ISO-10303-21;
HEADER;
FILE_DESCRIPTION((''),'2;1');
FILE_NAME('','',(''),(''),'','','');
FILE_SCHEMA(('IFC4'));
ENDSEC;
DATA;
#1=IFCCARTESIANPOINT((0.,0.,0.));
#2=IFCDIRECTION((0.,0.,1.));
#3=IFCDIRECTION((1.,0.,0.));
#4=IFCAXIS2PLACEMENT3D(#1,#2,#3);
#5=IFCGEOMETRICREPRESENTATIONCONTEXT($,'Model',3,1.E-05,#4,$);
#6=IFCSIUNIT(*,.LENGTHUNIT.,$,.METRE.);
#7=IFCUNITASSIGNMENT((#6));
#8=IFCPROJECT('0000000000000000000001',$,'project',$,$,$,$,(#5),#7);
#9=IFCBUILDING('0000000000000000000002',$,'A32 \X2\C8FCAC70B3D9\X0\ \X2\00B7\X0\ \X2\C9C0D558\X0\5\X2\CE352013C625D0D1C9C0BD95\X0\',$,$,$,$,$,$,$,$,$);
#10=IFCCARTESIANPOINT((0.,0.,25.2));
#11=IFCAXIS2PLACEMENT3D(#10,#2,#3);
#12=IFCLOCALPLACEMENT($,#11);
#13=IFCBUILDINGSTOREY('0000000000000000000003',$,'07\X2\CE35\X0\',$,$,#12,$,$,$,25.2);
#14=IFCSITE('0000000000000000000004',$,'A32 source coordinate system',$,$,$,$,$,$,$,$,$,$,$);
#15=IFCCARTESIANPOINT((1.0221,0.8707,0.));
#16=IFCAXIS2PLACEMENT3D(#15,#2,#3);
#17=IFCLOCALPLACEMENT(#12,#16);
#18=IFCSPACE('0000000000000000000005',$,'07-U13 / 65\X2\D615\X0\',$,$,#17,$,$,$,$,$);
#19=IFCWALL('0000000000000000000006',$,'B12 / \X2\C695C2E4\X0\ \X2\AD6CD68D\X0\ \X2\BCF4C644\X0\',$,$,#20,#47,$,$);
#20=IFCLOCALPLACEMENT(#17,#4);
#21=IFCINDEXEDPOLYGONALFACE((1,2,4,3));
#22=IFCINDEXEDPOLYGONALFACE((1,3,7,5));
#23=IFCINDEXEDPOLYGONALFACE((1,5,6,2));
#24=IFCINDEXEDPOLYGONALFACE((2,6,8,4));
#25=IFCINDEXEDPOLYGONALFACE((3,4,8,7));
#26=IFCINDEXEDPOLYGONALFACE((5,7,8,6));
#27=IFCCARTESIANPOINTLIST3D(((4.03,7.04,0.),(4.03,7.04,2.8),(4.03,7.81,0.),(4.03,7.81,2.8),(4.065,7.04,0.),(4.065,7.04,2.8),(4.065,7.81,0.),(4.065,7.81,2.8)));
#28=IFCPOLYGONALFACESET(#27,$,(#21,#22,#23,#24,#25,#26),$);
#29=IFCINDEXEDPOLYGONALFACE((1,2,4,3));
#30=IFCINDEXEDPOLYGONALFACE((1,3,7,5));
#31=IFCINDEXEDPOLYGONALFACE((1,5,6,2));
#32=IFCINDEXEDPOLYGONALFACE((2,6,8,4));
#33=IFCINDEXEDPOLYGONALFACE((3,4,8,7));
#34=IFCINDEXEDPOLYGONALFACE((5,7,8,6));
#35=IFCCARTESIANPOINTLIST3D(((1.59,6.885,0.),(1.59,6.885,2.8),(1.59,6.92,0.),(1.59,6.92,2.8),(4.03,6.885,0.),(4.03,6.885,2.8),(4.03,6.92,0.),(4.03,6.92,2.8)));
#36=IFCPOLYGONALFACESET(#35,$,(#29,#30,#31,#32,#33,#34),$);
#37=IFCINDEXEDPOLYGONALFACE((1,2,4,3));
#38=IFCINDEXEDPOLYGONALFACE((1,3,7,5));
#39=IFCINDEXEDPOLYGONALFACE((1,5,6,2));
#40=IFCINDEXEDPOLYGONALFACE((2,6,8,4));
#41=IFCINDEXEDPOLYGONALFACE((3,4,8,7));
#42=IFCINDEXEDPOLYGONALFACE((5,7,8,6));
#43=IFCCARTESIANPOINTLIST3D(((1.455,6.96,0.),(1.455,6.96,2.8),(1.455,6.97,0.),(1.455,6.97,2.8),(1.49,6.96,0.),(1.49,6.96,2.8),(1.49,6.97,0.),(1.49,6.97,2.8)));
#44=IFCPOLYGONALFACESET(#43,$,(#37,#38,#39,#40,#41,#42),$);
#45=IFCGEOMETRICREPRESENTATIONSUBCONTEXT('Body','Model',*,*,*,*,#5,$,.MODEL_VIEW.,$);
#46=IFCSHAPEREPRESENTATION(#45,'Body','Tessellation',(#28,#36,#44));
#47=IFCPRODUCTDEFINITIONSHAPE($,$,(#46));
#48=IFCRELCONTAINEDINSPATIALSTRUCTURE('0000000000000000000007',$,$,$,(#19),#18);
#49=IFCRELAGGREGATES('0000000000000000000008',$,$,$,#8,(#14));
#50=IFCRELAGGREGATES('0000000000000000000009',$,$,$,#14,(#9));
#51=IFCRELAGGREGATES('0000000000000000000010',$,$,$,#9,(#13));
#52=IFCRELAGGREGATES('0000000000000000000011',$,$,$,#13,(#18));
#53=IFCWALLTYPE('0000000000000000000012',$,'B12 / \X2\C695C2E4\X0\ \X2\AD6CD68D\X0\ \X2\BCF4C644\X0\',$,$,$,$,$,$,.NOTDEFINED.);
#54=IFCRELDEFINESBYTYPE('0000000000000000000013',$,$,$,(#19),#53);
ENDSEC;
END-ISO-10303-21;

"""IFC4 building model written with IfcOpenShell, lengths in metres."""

from ifc_helpers import new_model, si_unit, frame, origin, origin_with_axes, place, context, subcontext, project, spatial, polyline, outline, extrude, source, transform, mapped, type_object, type_shapes, element, save


model = new_model("IFC4")

# Units and contexts
model_context = context("Model", 3, precision=1e-05, world=origin_with_axes())
body_context = subcontext(model_context, "Body", "Model", "MODEL_VIEW")
ifc_project = project(units=[si_unit("LENGTHUNIT", "METRE")], contexts=[model_context])

# Site, building, storey, space
storey_placement = place(None, frame((0.0, 0.0, 25.2), z_axis=(0.0, 0.0, 1.0), x_axis=(1.0, 0.0, 0.0)))
space_placement = place(storey_placement, frame((1.0221, 0.8707, 0.0), z_axis=(0.0, 0.0, 1.0), x_axis=(1.0, 0.0, 0.0)))
site = spatial("IfcSite", under=ifc_project, Name="A32 source coordinate system")
building = spatial("IfcBuilding", under=site, Name="A32 주거동 · 지하5층–옥탑지붕")
storey = spatial("IfcBuildingStorey", under=building, at=storey_placement, Name="07층", Elevation=25.2)
space = spatial("IfcSpace", under=storey, at=space_placement, Name="07-U13 / 65형")

# Wall
wall_type_1 = type_object("IfcWallType", Name="B12 / 욕실 구획 보완", PredefinedType="NOTDEFINED")
shared_shape_1 = source(origin(), body_context, "Body", "SweptSolid", [
    extrude(outline(polyline([(4.065, 7.04), (4.03, 7.04), (4.03, 7.81), (4.065, 7.81), (4.065, 7.04)])), origin(), (0.0, 0.0, 1.0), 2.8),
    extrude(outline(polyline([(1.59, 6.92), (4.03, 6.92), (4.03, 6.885), (1.59, 6.885), (1.59, 6.92)])), origin(), (0.0, 0.0, 1.0), 2.8),
    extrude(outline(polyline([(1.455, 6.97), (1.49, 6.97), (1.49, 6.96), (1.455, 6.96), (1.455, 6.97)])), origin(), (0.0, 0.0, 1.0), 2.8),
])
type_shapes(wall_type_1, [shared_shape_1])
wall_1_placement = place(space_placement, origin_with_axes())
element("IfcWall", 1, at=wall_1_placement, inside=space, type_object=wall_type_1, Name="B12 / 욕실 구획 보완", context=body_context, shape_type="MappedRepresentation", body=[
    mapped(shared_shape_1, transform((0.0, 0.0, 0.0), scale=1.0)),
])

save(model, "model.ifc")
